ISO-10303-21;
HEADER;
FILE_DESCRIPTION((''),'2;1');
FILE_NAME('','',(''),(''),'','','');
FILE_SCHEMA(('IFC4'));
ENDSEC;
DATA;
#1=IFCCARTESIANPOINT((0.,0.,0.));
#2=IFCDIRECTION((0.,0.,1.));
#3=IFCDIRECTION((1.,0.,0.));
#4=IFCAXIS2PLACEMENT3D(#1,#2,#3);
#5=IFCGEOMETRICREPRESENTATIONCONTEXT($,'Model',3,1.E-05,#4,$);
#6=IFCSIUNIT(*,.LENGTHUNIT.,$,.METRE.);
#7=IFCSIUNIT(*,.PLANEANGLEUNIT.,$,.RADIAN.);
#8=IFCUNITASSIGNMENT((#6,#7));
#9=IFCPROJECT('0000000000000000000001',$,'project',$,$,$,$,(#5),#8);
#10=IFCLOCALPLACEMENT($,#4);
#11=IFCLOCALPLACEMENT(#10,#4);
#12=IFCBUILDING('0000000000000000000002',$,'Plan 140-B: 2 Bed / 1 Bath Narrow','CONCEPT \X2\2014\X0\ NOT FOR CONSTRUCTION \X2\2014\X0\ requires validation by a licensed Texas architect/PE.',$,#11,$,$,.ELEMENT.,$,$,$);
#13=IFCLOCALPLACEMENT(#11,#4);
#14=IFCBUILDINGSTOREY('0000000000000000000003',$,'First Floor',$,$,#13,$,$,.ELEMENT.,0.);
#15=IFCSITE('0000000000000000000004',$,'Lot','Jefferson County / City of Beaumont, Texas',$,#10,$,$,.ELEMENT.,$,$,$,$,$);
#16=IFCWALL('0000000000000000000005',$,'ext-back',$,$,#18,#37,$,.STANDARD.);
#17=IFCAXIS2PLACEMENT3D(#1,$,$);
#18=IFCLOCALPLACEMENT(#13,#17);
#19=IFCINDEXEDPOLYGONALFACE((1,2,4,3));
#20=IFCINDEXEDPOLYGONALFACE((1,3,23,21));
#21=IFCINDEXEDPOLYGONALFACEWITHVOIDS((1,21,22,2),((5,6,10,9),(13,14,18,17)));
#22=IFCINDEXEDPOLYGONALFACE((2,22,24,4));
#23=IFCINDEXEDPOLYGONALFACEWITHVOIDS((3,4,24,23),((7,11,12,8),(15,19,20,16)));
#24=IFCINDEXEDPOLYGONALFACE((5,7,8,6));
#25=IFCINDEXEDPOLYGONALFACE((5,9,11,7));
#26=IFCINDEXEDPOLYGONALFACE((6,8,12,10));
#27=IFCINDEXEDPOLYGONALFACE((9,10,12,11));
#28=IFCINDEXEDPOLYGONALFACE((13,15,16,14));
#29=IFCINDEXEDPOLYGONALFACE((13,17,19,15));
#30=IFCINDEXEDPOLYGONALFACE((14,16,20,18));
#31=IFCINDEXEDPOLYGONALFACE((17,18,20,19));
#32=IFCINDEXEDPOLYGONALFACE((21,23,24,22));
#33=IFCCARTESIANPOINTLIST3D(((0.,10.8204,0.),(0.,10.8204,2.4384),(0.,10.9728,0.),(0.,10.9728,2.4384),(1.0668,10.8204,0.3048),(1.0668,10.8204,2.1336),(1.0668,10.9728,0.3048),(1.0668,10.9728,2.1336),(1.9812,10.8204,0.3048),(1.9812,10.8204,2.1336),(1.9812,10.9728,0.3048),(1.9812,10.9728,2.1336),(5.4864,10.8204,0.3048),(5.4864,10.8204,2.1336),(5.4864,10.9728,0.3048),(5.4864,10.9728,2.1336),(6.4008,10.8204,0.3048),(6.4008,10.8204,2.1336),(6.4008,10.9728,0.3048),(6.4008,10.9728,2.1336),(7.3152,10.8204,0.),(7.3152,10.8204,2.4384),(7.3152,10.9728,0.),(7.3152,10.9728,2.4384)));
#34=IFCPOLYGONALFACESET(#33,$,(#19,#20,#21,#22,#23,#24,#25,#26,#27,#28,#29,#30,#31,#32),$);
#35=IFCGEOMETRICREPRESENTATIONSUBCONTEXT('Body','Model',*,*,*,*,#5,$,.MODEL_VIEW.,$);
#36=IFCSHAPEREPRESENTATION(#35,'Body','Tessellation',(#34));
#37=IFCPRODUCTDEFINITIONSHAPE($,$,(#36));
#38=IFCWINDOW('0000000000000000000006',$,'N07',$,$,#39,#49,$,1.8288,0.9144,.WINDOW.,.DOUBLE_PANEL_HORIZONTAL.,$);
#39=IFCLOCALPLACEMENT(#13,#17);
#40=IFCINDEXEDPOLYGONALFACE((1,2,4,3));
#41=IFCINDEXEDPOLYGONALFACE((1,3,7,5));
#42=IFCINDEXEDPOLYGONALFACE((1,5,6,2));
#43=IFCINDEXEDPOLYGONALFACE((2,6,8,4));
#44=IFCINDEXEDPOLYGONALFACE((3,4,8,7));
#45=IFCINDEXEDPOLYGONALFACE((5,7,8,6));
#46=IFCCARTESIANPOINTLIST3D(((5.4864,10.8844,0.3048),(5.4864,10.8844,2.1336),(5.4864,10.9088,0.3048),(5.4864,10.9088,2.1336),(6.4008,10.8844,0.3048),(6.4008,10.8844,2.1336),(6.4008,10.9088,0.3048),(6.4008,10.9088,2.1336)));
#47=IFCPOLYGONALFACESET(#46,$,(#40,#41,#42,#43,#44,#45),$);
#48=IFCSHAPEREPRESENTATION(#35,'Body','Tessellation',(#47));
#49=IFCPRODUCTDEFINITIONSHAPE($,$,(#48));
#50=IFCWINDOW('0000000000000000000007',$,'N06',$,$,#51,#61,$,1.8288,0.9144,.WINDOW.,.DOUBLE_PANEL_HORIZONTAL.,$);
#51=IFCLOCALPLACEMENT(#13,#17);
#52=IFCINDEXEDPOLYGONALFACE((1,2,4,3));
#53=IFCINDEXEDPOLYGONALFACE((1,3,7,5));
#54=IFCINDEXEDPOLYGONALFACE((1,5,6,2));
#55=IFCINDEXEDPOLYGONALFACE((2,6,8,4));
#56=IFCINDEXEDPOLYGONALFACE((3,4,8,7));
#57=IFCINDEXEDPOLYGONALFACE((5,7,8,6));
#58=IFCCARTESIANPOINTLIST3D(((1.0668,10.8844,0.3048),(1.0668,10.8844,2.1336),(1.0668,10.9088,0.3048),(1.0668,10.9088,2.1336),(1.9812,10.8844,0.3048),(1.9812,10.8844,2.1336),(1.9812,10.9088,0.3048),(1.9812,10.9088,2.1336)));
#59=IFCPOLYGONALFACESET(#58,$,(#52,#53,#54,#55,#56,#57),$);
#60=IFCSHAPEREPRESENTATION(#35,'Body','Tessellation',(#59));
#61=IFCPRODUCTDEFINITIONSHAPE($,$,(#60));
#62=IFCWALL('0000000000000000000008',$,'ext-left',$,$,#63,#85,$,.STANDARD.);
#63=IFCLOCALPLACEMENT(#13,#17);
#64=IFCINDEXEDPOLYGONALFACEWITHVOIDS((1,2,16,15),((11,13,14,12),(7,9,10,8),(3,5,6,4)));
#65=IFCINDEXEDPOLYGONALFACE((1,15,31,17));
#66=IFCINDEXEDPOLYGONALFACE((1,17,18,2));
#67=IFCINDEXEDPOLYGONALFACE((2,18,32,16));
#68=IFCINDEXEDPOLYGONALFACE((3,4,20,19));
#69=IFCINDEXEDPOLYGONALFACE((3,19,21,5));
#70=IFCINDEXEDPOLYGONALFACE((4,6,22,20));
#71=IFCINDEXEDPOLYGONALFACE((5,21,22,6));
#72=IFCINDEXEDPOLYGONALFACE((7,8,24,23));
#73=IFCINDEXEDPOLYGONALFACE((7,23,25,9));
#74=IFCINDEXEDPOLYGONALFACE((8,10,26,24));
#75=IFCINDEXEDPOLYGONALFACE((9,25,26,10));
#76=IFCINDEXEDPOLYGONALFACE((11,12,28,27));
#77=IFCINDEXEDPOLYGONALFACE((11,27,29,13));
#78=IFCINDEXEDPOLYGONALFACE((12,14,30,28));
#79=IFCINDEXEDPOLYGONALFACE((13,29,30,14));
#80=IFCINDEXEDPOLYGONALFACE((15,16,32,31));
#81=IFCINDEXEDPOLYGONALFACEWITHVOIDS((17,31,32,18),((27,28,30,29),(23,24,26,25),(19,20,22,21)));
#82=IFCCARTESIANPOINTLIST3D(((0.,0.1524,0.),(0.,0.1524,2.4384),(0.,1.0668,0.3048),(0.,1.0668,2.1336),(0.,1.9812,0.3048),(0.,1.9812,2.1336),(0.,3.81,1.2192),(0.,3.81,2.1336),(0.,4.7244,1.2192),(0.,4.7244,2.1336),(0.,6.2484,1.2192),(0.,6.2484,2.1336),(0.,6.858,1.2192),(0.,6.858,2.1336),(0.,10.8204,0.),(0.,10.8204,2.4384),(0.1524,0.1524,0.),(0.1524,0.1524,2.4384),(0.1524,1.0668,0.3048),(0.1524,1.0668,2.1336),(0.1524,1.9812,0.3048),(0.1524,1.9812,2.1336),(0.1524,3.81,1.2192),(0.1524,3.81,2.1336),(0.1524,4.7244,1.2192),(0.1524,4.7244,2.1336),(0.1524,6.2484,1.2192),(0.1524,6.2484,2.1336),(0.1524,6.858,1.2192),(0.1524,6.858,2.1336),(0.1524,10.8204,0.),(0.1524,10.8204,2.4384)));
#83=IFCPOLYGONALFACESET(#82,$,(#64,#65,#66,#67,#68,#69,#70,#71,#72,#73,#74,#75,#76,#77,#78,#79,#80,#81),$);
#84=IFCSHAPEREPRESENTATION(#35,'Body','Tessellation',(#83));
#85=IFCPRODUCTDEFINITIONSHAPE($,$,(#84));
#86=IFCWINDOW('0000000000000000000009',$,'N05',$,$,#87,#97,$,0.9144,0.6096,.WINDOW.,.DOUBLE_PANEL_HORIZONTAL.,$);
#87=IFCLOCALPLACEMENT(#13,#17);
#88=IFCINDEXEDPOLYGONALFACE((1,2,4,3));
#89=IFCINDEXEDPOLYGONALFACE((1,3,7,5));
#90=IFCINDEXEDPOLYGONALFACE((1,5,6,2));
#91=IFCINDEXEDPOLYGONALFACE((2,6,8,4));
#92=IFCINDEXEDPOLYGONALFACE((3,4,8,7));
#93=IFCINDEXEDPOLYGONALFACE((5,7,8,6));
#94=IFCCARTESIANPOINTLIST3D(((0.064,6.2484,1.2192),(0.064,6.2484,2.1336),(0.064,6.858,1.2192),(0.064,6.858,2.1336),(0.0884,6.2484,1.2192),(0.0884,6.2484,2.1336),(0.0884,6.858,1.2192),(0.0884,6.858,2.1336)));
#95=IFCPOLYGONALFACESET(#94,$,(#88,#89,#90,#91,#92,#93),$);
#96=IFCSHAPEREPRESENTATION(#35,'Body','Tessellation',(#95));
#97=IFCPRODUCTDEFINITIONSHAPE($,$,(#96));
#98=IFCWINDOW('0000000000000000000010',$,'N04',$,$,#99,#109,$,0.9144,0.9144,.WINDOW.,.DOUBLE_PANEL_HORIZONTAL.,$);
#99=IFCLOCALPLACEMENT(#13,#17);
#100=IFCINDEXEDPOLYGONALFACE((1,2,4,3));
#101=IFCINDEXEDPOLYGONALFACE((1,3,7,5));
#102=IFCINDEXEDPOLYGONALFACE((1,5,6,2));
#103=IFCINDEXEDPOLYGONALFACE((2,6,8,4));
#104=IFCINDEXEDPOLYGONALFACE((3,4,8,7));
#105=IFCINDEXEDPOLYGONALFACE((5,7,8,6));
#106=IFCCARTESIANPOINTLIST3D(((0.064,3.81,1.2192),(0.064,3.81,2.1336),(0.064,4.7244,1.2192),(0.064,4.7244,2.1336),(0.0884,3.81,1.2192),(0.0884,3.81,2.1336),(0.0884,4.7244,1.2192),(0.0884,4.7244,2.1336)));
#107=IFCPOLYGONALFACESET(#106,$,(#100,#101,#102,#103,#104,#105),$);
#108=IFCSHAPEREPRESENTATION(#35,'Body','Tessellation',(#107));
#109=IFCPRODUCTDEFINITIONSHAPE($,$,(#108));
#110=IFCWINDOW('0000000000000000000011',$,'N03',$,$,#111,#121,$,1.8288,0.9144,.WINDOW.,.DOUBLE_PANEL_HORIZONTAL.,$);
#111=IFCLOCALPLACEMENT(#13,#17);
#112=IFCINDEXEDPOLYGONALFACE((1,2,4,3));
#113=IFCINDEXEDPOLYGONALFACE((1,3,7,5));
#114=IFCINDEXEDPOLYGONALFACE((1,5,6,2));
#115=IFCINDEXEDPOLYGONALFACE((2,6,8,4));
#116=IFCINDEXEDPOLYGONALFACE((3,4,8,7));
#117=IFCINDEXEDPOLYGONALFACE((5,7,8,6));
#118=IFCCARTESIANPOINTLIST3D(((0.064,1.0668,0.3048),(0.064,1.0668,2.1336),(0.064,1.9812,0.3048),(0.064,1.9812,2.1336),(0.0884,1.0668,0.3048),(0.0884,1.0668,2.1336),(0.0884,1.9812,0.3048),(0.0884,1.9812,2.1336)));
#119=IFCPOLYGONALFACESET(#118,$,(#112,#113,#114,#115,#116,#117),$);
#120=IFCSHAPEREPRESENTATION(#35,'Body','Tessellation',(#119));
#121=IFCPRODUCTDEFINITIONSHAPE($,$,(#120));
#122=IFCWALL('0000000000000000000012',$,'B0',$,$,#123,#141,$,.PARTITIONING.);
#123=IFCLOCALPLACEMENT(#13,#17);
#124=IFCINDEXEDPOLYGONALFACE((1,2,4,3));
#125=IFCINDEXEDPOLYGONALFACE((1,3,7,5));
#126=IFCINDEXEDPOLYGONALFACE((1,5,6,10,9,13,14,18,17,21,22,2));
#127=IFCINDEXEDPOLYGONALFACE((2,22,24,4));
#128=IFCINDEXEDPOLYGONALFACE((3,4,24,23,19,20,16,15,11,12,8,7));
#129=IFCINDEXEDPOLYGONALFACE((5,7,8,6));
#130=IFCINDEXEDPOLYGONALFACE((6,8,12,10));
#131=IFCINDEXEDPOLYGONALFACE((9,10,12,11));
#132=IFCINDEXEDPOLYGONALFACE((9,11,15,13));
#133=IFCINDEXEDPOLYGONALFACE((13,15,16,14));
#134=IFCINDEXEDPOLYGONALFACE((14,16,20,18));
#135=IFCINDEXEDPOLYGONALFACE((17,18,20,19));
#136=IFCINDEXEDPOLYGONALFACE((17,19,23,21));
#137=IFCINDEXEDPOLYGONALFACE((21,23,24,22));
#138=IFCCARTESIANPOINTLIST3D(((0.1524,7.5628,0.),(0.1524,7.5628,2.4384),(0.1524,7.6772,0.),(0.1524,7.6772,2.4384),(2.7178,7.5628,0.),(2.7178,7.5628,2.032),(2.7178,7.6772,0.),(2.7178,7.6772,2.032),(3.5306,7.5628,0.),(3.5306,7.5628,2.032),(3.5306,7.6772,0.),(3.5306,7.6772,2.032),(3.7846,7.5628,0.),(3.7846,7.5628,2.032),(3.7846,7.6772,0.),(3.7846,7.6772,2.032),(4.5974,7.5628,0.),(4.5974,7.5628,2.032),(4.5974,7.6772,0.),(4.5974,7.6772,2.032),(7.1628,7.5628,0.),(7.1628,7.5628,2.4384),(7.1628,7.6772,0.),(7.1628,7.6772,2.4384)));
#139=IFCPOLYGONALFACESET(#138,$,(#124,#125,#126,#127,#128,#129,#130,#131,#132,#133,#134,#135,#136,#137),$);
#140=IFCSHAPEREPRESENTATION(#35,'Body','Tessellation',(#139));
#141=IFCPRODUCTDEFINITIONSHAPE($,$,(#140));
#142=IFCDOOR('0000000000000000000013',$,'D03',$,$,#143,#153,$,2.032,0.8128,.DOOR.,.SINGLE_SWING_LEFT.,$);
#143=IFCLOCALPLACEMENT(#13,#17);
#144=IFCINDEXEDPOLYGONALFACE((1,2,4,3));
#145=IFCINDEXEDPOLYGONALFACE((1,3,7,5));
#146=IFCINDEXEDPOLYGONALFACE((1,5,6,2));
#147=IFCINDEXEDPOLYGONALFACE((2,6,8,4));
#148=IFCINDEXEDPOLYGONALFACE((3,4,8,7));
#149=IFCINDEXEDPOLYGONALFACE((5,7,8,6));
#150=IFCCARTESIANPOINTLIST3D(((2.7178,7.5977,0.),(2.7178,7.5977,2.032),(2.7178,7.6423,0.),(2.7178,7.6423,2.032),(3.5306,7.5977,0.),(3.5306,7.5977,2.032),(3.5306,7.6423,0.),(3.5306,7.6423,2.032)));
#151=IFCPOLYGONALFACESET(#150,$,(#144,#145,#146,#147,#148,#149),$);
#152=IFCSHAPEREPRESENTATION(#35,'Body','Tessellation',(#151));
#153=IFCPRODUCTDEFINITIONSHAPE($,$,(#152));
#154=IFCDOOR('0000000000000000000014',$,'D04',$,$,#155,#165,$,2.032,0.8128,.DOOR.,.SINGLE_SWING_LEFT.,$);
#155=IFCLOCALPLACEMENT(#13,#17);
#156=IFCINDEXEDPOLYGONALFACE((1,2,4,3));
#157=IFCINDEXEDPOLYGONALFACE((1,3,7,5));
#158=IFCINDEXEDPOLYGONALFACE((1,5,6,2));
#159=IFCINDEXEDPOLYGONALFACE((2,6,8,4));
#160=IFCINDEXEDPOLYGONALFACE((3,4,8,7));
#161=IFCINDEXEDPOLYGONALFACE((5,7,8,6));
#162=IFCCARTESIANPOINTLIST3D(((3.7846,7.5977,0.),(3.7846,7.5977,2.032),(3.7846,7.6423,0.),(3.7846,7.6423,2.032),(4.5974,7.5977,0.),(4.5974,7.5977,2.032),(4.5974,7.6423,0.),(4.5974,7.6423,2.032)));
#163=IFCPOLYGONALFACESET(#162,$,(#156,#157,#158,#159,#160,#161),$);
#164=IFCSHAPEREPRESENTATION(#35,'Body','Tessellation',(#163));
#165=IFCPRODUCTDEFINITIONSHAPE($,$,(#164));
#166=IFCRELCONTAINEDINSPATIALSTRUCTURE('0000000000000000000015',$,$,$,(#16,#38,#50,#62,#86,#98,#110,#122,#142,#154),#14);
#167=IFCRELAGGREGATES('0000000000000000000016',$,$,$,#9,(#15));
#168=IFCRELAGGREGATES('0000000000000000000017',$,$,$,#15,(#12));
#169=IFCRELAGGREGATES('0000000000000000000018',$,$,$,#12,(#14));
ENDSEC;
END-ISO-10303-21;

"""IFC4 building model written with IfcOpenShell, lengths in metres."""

from ifc_helpers import new_model, si_unit, frame, frame_2d, origin_with_axes, place, context, subcontext, project, spatial, rectangle, extrude, element, fill, save


model = new_model("IFC4")

# Units and contexts
model_context = context("Model", 3, precision=1e-05, world=origin_with_axes())
body_context = subcontext(model_context, "Body", "Model", "MODEL_VIEW")
ifc_project = project(units=[si_unit("LENGTHUNIT", "METRE"), si_unit("PLANEANGLEUNIT", "RADIAN")], contexts=[model_context])

# Site, building, storey
site_placement = place(None, origin_with_axes())
site = spatial("IfcSite", under=ifc_project, at=site_placement, Name="Lot", Description="Jefferson County / City of Beaumont, Texas", CompositionType="ELEMENT")
building_placement = place(site_placement, origin_with_axes())
building = spatial("IfcBuilding", under=site, at=building_placement, Name="Plan 140-B: 2 Bed / 1 Bath Narrow", Description="CONCEPT — NOT FOR CONSTRUCTION — requires validation by a licensed Texas architect/PE.", CompositionType="ELEMENT")
storey_placement = place(building_placement, origin_with_axes())
storey = spatial("IfcBuildingStorey", under=building, at=storey_placement, Name="First Floor", CompositionType="ELEMENT", Elevation=0.0)

# Walls, openings, windows
wall_1_placement = place(storey_placement, frame((7.3152, 10.8966, 0.0), z_axis=(0.0, 0.0, 1.0), x_axis=(-1.0, 0.0, 0.0)))
wall_1 = element("IfcWall", 1, at=wall_1_placement, inside=storey, Name="ext-back", PredefinedType="STANDARD", context=body_context, shape_type="SweptSolid", body=[
    extrude(rectangle(XDim=7.3152, YDim=0.1524, at=frame_2d((3.6576, 0.0), x_axis=(1.0, 0.0))), origin_with_axes(), (0.0, 0.0, 1.0), 2.4384),
])
opening_1_placement = place(wall_1_placement, frame((0.9144, 0.0, 0.3048), z_axis=(0.0, 0.0, 1.0), x_axis=(1.0, 0.0, 0.0)))
opening_1 = element("IfcOpeningElement", 2, at=opening_1_placement, cuts=wall_1, PredefinedType="OPENING", context=body_context, shape_type="SweptSolid", body=[
    extrude(rectangle(XDim=0.9144, YDim=0.1829, at=frame_2d((0.4572, 0.0), x_axis=(1.0, 0.0))), origin_with_axes(), (0.0, 0.0, 1.0), 1.8288),
])
opening_2_placement = place(wall_1_placement, frame((5.334, 0.0, 0.3048), z_axis=(0.0, 0.0, 1.0), x_axis=(1.0, 0.0, 0.0)))
opening_2 = element("IfcOpeningElement", 3, at=opening_2_placement, cuts=wall_1, PredefinedType="OPENING", context=body_context, shape_type="SweptSolid", body=[
    extrude(rectangle(XDim=0.9144, YDim=0.1829, at=frame_2d((0.4572, 0.0), x_axis=(1.0, 0.0))), origin_with_axes(), (0.0, 0.0, 1.0), 1.8288),
])
window_1_placement = place(opening_1_placement, origin_with_axes())
window_1 = element("IfcWindow", 4, at=window_1_placement, inside=storey, Name="N07", OverallHeight=1.8288, OverallWidth=0.9144, PartitioningType="DOUBLE_PANEL_HORIZONTAL", PredefinedType="WINDOW", context=body_context, shape_type="SweptSolid", body=[
    extrude(rectangle(XDim=0.9144, YDim=0.0244, at=frame_2d((0.4572, 0.0), x_axis=(1.0, 0.0))), origin_with_axes(), (0.0, 0.0, 1.0), 1.8288),
])
fill(opening_1, window_1)
window_2_placement = place(opening_2_placement, origin_with_axes())
window_2 = element("IfcWindow", 5, at=window_2_placement, inside=storey, Name="N06", OverallHeight=1.8288, OverallWidth=0.9144, PartitioningType="DOUBLE_PANEL_HORIZONTAL", PredefinedType="WINDOW", context=body_context, shape_type="SweptSolid", body=[
    extrude(rectangle(XDim=0.9144, YDim=0.0244, at=frame_2d((0.4572, 0.0), x_axis=(1.0, 0.0))), origin_with_axes(), (0.0, 0.0, 1.0), 1.8288),
])
fill(opening_2, window_2)
wall_2_placement = place(storey_placement, frame((0.0762, 10.8204, 0.0), z_axis=(0.0, 0.0, 1.0), x_axis=(0.0, -1.0, 0.0)))
wall_2 = element("IfcWall", 6, at=wall_2_placement, inside=storey, Name="ext-left", PredefinedType="STANDARD", context=body_context, shape_type="SweptSolid", body=[
    extrude(rectangle(XDim=10.668, YDim=0.1524, at=frame_2d((5.334, 0.0), x_axis=(1.0, 0.0))), origin_with_axes(), (0.0, 0.0, 1.0), 2.4384),
])
opening_3_placement = place(wall_2_placement, frame((3.9624, 0.0, 1.2192), z_axis=(0.0, 0.0, 1.0), x_axis=(1.0, 0.0, 0.0)))
opening_3 = element("IfcOpeningElement", 7, at=opening_3_placement, cuts=wall_2, PredefinedType="OPENING", context=body_context, shape_type="SweptSolid", body=[
    extrude(rectangle(XDim=0.6096, YDim=0.1829, at=frame_2d((0.3048, 0.0), x_axis=(1.0, 0.0))), origin_with_axes(), (0.0, 0.0, 1.0), 0.9144),
])
opening_4_placement = place(wall_2_placement, frame((6.096, 0.0, 1.2192), z_axis=(0.0, 0.0, 1.0), x_axis=(1.0, 0.0, 0.0)))
opening_4 = element("IfcOpeningElement", 8, at=opening_4_placement, cuts=wall_2, PredefinedType="OPENING", context=body_context, shape_type="SweptSolid", body=[
    extrude(rectangle(XDim=0.9144, YDim=0.1829, at=frame_2d((0.4572, 0.0), x_axis=(1.0, 0.0))), origin_with_axes(), (0.0, 0.0, 1.0), 0.9144),
])
opening_5_placement = place(wall_2_placement, frame((8.8392, 0.0, 0.3048), z_axis=(0.0, 0.0, 1.0), x_axis=(1.0, 0.0, 0.0)))
opening_5 = element("IfcOpeningElement", 9, at=opening_5_placement, cuts=wall_2, PredefinedType="OPENING", context=body_context, shape_type="SweptSolid", body=[
    extrude(rectangle(XDim=0.9144, YDim=0.1829, at=frame_2d((0.4572, 0.0), x_axis=(1.0, 0.0))), origin_with_axes(), (0.0, 0.0, 1.0), 1.8288),
])
window_3_placement = place(opening_3_placement, origin_with_axes())
window_3 = element("IfcWindow", 10, at=window_3_placement, inside=storey, Name="N05", OverallHeight=0.9144, OverallWidth=0.6096, PartitioningType="DOUBLE_PANEL_HORIZONTAL", PredefinedType="WINDOW", context=body_context, shape_type="SweptSolid", body=[
    extrude(rectangle(XDim=0.6096, YDim=0.0244, at=frame_2d((0.3048, 0.0), x_axis=(1.0, 0.0))), origin_with_axes(), (0.0, 0.0, 1.0), 0.9144),
])
fill(opening_3, window_3)
window_4_placement = place(opening_4_placement, origin_with_axes())
window_4 = element("IfcWindow", 11, at=window_4_placement, inside=storey, Name="N04", OverallHeight=0.9144, OverallWidth=0.9144, PartitioningType="DOUBLE_PANEL_HORIZONTAL", PredefinedType="WINDOW", context=body_context, shape_type="SweptSolid", body=[
    extrude(rectangle(XDim=0.9144, YDim=0.0244, at=frame_2d((0.4572, 0.0), x_axis=(1.0, 0.0))), origin_with_axes(), (0.0, 0.0, 1.0), 0.9144),
])
fill(opening_4, window_4)
window_5_placement = place(opening_5_placement, origin_with_axes())
window_5 = element("IfcWindow", 12, at=window_5_placement, inside=storey, Name="N03", OverallHeight=1.8288, OverallWidth=0.9144, PartitioningType="DOUBLE_PANEL_HORIZONTAL", PredefinedType="WINDOW", context=body_context, shape_type="SweptSolid", body=[
    extrude(rectangle(XDim=0.9144, YDim=0.0244, at=frame_2d((0.4572, 0.0), x_axis=(1.0, 0.0))), origin_with_axes(), (0.0, 0.0, 1.0), 1.8288),
])
fill(opening_5, window_5)

# Wall, openings, doors
wall_3_placement = place(storey_placement, frame((0.1524, 7.62, 0.0), z_axis=(0.0, 0.0, 1.0), x_axis=(1.0, 0.0, 0.0)))
wall_3 = element("IfcWall", 13, at=wall_3_placement, inside=storey, Name="B0", PredefinedType="PARTITIONING", context=body_context, shape_type="SweptSolid", body=[
    extrude(rectangle(XDim=7.0104, YDim=0.1143, at=frame_2d((3.5052, 0.0), x_axis=(1.0, 0.0))), origin_with_axes(), (0.0, 0.0, 1.0), 2.4384),
])
opening_6_placement = place(wall_3_placement, frame((2.5654, 0.0, 0.0), z_axis=(0.0, 0.0, 1.0), x_axis=(1.0, 0.0, 0.0)))
opening_6 = element("IfcOpeningElement", 14, at=opening_6_placement, cuts=wall_3, PredefinedType="OPENING", context=body_context, shape_type="SweptSolid", body=[
    extrude(rectangle(XDim=0.8128, YDim=0.1448, at=frame_2d((0.4064, 0.0), x_axis=(1.0, 0.0))), origin_with_axes(), (0.0, 0.0, 1.0), 2.032),
])
opening_7_placement = place(wall_3_placement, frame((3.6322, 0.0, 0.0), z_axis=(0.0, 0.0, 1.0), x_axis=(1.0, 0.0, 0.0)))
opening_7 = element("IfcOpeningElement", 15, at=opening_7_placement, cuts=wall_3, PredefinedType="OPENING", context=body_context, shape_type="SweptSolid", body=[
    extrude(rectangle(XDim=0.8128, YDim=0.1448, at=frame_2d((0.4064, 0.0), x_axis=(1.0, 0.0))), origin_with_axes(), (0.0, 0.0, 1.0), 2.032),
])
door_1_placement = place(opening_6_placement, origin_with_axes())
door_1 = element("IfcDoor", 16, at=door_1_placement, inside=storey, Name="D03", OperationType="SINGLE_SWING_LEFT", OverallHeight=2.032, OverallWidth=0.8128, PredefinedType="DOOR", context=body_context, shape_type="SweptSolid", body=[
    extrude(rectangle(XDim=0.8128, YDim=0.0445, at=frame_2d((0.4064, 0.0), x_axis=(1.0, 0.0))), origin_with_axes(), (0.0, 0.0, 1.0), 2.032),
])
fill(opening_6, door_1)
door_2_placement = place(opening_7_placement, origin_with_axes())
door_2 = element("IfcDoor", 17, at=door_2_placement, inside=storey, Name="D04", OperationType="SINGLE_SWING_LEFT", OverallHeight=2.032, OverallWidth=0.8128, PredefinedType="DOOR", context=body_context, shape_type="SweptSolid", body=[
    extrude(rectangle(XDim=0.8128, YDim=0.0445, at=frame_2d((0.4064, 0.0), x_axis=(1.0, 0.0))), origin_with_axes(), (0.0, 0.0, 1.0), 2.032),
])
fill(opening_7, door_2)

save(model, "model.ifc")
